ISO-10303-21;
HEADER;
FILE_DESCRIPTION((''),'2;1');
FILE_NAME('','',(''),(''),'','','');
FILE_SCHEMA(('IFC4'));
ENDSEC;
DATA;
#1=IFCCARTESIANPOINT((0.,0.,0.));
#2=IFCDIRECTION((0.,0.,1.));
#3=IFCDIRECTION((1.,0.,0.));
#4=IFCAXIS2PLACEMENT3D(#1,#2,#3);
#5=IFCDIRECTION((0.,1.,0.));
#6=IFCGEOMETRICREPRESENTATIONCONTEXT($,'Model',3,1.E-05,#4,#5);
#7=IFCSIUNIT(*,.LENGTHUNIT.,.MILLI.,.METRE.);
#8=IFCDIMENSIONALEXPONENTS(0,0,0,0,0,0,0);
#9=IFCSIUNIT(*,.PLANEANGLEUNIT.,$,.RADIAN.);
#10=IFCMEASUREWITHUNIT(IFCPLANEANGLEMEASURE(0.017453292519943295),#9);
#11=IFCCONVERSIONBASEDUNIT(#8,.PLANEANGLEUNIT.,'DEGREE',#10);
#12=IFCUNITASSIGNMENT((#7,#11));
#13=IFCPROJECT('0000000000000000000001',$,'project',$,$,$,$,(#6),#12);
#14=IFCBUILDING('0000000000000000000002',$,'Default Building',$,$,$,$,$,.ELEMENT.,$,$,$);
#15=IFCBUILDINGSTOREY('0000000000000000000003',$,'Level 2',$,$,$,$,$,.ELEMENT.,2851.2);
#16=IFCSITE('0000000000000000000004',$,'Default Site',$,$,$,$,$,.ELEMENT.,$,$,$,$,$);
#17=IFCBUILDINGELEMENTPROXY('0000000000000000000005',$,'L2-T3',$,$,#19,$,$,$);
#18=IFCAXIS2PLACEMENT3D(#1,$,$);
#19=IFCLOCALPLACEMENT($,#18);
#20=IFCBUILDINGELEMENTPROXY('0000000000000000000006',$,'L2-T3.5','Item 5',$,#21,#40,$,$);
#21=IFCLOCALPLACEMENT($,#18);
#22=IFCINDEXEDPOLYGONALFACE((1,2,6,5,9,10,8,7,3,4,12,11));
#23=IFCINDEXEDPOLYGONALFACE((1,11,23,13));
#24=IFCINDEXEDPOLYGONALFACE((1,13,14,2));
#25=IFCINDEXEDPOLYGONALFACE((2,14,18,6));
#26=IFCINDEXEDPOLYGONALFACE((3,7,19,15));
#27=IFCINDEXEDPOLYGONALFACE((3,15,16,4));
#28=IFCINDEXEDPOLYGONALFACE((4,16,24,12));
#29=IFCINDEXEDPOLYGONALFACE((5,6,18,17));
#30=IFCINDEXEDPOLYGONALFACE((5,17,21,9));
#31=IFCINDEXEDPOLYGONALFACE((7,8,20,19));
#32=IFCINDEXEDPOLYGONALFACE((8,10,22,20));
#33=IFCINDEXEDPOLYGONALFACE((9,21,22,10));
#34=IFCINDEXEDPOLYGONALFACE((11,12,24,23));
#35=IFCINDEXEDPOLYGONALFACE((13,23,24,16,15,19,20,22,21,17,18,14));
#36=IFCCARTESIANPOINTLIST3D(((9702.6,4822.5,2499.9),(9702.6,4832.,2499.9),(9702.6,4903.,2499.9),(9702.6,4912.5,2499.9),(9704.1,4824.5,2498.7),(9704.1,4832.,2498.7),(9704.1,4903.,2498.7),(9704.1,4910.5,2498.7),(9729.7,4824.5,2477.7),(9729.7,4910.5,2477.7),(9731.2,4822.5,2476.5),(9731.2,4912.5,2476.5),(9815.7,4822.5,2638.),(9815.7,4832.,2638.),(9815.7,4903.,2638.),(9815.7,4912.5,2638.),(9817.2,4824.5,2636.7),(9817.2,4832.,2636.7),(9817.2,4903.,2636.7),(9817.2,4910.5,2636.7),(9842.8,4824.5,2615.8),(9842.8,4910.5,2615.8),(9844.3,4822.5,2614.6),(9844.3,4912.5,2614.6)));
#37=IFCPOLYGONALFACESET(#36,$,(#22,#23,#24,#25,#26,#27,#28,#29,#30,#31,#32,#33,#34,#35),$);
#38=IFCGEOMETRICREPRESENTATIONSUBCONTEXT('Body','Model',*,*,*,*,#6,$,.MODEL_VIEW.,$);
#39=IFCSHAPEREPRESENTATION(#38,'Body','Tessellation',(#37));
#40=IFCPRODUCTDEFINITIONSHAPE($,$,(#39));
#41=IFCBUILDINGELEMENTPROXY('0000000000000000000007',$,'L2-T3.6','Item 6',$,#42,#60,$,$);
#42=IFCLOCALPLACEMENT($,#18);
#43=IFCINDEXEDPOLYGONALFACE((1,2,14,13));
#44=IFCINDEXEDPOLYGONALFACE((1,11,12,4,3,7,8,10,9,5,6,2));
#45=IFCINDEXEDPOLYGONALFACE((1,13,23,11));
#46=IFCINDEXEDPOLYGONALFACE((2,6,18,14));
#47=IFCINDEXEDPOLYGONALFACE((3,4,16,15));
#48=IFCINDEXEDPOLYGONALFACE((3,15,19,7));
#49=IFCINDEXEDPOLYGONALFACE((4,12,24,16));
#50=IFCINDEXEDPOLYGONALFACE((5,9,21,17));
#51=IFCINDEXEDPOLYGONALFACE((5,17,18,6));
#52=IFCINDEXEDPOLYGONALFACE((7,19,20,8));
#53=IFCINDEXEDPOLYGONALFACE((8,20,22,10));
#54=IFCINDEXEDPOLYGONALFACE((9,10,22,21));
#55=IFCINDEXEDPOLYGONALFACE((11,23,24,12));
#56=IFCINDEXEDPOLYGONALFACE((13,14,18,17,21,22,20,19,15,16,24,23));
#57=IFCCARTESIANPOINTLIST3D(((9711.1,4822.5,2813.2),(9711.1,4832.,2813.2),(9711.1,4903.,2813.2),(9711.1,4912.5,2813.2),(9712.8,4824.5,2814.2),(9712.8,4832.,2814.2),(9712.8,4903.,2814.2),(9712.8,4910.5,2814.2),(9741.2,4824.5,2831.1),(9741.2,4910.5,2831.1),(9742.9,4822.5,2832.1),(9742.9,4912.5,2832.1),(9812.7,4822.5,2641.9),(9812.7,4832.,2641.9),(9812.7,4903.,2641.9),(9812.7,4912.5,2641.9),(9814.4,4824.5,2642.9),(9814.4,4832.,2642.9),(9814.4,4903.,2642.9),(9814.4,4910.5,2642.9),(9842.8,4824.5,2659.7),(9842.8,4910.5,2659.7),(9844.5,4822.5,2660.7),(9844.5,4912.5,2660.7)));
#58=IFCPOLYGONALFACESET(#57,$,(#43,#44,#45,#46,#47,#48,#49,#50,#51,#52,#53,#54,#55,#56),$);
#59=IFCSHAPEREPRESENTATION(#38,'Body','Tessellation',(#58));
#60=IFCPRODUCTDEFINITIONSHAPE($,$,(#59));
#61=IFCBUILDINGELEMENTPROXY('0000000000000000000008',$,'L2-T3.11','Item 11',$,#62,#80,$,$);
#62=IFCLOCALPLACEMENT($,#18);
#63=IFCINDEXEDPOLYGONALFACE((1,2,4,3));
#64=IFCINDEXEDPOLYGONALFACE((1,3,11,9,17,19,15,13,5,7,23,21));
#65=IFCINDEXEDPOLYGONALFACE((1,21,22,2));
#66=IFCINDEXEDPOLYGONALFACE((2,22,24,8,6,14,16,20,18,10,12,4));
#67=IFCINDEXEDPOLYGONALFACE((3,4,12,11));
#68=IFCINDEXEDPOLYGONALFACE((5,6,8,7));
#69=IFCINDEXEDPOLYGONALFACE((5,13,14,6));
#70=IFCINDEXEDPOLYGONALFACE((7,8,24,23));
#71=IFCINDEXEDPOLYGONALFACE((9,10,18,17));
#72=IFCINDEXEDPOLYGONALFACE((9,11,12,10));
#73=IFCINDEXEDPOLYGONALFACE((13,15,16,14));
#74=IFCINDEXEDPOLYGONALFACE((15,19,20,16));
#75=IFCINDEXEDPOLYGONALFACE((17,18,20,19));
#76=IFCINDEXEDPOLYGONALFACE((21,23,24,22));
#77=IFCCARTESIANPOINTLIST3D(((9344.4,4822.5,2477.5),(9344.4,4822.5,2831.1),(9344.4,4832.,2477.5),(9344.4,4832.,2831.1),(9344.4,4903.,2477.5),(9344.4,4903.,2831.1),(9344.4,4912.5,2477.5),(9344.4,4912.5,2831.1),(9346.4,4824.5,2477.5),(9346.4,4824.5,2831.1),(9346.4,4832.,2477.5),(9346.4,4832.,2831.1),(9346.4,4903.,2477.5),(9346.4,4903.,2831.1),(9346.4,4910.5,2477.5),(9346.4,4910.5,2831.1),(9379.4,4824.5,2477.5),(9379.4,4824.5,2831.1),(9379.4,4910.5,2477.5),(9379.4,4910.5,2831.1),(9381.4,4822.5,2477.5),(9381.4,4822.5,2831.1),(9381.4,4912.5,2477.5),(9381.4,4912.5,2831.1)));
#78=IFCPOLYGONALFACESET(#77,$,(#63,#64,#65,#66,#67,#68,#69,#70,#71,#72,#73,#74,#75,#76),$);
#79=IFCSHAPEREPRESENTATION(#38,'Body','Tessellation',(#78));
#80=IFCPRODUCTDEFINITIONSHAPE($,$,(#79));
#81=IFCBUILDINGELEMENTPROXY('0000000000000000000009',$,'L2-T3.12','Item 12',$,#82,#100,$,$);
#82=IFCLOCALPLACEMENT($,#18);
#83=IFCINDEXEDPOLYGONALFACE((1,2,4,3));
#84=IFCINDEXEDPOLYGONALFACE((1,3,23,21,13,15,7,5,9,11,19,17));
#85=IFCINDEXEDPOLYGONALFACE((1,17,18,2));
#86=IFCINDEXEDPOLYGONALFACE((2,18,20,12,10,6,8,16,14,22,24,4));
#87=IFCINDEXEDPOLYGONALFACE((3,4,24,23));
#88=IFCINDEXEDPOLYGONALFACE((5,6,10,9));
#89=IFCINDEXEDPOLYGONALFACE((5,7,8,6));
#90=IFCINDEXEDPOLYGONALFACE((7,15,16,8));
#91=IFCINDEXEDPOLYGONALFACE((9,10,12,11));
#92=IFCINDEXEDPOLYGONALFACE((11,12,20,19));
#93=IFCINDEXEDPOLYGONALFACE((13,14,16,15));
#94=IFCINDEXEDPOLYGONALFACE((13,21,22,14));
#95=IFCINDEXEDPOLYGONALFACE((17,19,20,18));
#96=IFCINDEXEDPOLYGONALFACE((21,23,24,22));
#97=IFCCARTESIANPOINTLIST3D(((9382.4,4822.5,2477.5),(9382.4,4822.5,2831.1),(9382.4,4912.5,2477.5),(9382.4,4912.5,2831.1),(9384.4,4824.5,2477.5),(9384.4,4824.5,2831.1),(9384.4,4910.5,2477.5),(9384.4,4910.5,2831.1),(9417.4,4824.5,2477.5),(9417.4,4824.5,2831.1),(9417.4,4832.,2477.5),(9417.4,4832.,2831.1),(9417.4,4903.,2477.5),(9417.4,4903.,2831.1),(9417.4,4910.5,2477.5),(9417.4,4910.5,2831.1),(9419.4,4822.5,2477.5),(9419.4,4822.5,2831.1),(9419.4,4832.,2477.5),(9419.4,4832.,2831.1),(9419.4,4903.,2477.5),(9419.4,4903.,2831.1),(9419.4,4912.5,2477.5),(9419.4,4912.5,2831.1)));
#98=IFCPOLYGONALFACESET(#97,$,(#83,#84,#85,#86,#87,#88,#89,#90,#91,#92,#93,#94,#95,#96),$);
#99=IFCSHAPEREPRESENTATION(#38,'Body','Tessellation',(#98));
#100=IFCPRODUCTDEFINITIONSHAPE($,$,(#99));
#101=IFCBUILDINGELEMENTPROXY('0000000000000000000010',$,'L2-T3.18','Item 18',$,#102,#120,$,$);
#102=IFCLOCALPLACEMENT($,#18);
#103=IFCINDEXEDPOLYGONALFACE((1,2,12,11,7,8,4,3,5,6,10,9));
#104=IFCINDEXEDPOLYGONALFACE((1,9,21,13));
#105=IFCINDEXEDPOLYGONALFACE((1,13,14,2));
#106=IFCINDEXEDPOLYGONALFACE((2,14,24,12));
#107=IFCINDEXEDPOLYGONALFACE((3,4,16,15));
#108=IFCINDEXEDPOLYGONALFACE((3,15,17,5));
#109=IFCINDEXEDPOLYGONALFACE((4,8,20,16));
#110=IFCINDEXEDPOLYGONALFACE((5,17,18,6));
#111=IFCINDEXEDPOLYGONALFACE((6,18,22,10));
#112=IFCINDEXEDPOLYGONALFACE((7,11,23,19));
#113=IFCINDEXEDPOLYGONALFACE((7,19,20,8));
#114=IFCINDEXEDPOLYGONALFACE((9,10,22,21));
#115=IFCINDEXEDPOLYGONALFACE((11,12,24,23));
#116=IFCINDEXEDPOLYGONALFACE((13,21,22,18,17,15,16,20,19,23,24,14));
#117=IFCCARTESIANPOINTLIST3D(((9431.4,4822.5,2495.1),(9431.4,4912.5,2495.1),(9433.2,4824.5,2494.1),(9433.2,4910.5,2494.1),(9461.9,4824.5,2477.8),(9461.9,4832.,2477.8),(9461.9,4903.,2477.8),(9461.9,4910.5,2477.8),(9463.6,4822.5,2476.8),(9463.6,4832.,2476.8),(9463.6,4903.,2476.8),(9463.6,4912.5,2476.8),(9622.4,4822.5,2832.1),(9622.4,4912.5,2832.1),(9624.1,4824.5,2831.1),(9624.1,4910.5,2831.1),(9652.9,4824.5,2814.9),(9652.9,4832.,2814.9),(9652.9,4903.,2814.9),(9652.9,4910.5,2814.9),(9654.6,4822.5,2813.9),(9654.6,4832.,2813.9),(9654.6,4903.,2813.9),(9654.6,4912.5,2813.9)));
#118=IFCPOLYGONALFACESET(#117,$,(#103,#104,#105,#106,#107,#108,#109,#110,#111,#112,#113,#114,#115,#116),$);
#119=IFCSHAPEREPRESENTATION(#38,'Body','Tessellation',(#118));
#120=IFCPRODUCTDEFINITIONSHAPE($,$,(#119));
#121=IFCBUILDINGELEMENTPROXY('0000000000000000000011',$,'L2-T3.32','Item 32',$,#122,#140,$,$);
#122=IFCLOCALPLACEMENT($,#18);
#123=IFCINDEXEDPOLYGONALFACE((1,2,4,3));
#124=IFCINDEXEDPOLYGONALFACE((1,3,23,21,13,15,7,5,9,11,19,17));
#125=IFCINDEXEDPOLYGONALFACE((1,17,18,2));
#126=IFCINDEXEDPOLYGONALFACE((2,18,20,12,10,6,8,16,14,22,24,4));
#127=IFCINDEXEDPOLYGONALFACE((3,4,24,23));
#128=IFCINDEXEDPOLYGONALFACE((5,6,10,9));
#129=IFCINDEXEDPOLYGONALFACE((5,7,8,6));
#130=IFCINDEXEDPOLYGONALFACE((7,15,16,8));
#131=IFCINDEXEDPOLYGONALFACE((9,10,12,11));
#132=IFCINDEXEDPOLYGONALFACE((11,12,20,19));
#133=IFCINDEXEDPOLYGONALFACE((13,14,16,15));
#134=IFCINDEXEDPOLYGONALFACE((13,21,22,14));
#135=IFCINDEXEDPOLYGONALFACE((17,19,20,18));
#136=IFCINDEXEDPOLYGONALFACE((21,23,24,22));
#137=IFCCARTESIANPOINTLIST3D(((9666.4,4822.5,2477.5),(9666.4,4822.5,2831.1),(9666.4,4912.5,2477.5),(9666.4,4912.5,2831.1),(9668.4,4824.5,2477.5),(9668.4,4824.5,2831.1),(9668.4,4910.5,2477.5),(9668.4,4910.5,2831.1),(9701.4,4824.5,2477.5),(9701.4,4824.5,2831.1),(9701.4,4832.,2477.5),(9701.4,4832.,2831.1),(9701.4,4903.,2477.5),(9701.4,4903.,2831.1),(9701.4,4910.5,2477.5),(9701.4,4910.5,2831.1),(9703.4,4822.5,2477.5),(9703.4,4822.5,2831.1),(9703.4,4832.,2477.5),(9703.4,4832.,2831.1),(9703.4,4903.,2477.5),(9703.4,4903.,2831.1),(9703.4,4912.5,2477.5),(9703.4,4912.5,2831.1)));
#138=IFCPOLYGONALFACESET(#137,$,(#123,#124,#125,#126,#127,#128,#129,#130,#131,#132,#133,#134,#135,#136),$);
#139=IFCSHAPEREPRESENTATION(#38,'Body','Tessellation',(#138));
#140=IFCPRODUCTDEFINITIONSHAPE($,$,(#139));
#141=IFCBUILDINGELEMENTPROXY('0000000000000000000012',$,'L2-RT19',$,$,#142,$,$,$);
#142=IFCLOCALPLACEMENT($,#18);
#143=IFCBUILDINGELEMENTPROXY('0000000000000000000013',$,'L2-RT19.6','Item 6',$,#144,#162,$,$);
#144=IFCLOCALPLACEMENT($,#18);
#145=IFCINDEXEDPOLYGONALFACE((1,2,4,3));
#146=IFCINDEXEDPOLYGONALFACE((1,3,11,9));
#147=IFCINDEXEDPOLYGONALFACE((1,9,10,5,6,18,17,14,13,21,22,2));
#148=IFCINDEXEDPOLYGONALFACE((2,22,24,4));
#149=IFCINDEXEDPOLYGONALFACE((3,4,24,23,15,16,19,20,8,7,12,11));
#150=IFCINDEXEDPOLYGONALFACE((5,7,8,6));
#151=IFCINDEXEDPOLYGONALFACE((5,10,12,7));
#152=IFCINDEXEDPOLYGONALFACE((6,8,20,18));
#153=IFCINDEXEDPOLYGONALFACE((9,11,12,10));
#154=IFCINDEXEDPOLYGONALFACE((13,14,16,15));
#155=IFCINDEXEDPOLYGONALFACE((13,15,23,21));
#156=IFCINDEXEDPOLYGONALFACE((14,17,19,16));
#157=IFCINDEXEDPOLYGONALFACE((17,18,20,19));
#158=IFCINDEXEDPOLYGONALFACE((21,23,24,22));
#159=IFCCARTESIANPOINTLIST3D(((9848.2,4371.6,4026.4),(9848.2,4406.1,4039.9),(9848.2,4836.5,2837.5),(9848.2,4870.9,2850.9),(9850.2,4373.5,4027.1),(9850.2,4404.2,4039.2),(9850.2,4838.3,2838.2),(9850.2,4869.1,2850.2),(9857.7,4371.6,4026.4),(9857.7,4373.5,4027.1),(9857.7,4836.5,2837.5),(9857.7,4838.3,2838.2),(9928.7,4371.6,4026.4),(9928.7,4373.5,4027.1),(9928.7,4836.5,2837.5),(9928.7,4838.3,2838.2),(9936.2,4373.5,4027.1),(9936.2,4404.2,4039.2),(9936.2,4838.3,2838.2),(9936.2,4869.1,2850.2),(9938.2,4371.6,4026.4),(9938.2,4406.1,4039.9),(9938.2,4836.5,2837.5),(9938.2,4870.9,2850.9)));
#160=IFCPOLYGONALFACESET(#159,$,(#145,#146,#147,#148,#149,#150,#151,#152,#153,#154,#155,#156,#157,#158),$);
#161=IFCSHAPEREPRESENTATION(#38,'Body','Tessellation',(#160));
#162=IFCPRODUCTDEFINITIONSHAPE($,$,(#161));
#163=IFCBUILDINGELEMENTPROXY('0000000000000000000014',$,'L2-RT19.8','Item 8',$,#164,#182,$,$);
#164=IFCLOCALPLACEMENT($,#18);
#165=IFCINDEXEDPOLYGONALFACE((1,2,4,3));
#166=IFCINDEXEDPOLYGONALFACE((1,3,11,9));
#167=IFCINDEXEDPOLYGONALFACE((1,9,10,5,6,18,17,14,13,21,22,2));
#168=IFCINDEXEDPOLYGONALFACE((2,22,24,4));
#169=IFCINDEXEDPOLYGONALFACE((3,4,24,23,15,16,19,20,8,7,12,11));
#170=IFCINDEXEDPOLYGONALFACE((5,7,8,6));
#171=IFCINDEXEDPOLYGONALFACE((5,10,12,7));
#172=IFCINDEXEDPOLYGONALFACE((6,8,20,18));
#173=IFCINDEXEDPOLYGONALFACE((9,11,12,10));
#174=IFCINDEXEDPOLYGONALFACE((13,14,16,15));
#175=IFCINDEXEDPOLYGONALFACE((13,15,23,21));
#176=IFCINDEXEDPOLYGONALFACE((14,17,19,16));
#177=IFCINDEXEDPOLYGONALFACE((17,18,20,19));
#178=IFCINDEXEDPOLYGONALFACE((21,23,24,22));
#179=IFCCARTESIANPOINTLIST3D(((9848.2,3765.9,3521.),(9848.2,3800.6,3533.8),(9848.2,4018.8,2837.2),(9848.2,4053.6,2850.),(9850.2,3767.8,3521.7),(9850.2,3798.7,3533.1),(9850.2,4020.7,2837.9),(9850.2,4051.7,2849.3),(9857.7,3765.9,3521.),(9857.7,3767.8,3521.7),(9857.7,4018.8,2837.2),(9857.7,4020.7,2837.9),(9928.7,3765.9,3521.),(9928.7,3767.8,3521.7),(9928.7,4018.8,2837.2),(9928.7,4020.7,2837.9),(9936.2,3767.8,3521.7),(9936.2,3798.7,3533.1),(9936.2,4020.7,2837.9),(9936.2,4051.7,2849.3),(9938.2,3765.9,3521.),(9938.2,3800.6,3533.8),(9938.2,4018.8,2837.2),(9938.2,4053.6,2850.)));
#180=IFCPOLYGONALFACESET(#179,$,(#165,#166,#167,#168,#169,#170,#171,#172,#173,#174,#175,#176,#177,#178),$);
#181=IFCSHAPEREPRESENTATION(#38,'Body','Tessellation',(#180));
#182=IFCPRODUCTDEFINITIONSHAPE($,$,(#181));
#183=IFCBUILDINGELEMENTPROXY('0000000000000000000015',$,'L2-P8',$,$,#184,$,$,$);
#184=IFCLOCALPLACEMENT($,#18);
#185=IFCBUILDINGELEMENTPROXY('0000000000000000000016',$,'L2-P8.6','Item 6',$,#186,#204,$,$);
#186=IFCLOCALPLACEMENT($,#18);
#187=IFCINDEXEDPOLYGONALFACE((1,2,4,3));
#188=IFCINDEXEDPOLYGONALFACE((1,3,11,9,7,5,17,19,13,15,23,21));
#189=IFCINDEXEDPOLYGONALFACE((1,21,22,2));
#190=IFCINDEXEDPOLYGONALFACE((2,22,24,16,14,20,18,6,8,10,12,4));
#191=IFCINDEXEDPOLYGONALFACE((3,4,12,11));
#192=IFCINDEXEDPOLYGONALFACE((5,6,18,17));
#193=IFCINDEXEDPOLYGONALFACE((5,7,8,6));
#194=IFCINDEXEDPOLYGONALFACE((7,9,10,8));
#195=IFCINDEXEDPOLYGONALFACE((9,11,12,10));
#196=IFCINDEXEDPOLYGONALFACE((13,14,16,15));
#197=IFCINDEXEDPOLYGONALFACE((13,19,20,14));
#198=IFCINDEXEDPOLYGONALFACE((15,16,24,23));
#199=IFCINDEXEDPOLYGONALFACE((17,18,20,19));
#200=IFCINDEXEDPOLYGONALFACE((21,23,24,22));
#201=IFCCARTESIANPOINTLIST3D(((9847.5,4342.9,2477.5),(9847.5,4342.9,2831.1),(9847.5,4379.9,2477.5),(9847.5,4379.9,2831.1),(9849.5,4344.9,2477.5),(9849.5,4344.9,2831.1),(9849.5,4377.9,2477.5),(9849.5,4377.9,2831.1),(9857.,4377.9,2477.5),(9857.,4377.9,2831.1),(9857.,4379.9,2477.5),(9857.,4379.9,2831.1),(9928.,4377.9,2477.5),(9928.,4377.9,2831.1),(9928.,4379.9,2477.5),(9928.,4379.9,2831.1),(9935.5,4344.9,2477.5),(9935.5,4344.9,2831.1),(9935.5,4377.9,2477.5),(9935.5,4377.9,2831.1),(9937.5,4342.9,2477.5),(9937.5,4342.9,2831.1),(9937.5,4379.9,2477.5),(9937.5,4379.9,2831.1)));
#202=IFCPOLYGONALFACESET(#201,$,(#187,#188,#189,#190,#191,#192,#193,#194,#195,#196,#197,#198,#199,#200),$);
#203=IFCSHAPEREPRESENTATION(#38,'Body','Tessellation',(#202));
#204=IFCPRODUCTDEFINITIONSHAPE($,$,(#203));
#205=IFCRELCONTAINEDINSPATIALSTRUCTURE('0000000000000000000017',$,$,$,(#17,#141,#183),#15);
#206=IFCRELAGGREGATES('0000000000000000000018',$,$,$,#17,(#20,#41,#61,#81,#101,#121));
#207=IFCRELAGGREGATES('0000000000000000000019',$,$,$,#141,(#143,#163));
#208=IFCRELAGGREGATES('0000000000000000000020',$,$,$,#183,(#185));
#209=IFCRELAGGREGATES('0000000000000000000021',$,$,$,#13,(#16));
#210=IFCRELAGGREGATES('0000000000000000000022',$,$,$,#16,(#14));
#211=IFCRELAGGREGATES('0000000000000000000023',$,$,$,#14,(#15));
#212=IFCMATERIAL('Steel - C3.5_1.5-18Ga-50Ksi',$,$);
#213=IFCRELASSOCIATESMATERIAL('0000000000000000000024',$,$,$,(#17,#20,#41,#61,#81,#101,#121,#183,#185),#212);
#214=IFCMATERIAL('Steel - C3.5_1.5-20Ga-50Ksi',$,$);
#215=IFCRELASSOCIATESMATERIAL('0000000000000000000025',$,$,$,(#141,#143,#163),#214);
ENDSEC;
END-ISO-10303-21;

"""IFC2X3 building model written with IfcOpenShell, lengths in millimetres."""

from ifc_helpers import new_model, entity, si_unit, converted_unit, direction, frame, origin, origin_with_axes, origin_2d_with_axis, place, context, subcontext, project, spatial, c_section, extrude, material, element, aggregate, save


model = new_model("IFC2X3")

# Units and contexts
model_context = context("Model", 3, precision=1e-05, world=origin_with_axes(), true_north=direction((0.0, 1.0, 0.0)))
body_context = subcontext(model_context, "Body", "Model", "MODEL_VIEW")
ifc_project = project(units=[si_unit("LENGTHUNIT", "METRE", prefix="MILLI"), converted_unit("PLANEANGLEUNIT", "DEGREE", entity("IfcPlaneAngleMeasure", 0.017453292519943295), si_unit("PLANEANGLEUNIT", "RADIAN"), dimensions=[0, 0, 0, 0, 0, 0, 0])], contexts=[model_context])

# Site, building, storey
site = spatial("IfcSite", under=ifc_project, Name="Default Site", CompositionType="ELEMENT")
building = spatial("IfcBuilding", under=site, Name="Default Building", CompositionType="ELEMENT")
storey = spatial("IfcBuildingStorey", under=building, Name="Level 2", CompositionType="ELEMENT", Elevation=2851.2)

# Building element proxies
ifc_material_1 = material(Name="Steel - C3.5_1.5-18Ga-50Ksi")
proxy_1 = element("IfcBuildingElementProxy", 1, inside=storey, material=ifc_material_1, Name="L2-T3")
proxy_2_placement = place(None, frame((9716.9, 4867.5, 2488.2), z_axis=(0.634, 0.0, 0.774), x_axis=(-28.628, 0.0, 23.44)))
proxy_2 = element("IfcBuildingElementProxy", 2, at=proxy_2_placement, material=ifc_material_1, Name="L2-T3.5", Description="Item 5", context=body_context, shape_type="SweptSolid", body=[
    extrude(c_section(Depth=90.0, Width=37.0, WallThickness=2.0, Girth=9.5, at=origin_2d_with_axis()), origin(), (0.0, 0.0, 1.0), 178.5),
])
proxy_3_placement = place(None, frame((9828.6, 4867.5, 2651.3), z_axis=(-0.51, 0.0, 0.86), x_axis=(-31.825, 0.0, -18.873)))
proxy_3 = element("IfcBuildingElementProxy", 3, at=proxy_3_placement, material=ifc_material_1, Name="L2-T3.6", Description="Item 6", context=body_context, shape_type="SweptSolid", body=[
    extrude(c_section(Depth=90.0, Width=37.0, WallThickness=2.0, Girth=9.5, at=origin_2d_with_axis()), origin(), (0.0, 0.0, 1.0), 199.2),
])
proxy_4_placement = place(None, frame((9362.9, 4867.5, 2477.5), z_axis=(0.0, 0.0, 1.0), x_axis=(-37.0, 0.0, 0.0)))
proxy_4 = element("IfcBuildingElementProxy", 4, at=proxy_4_placement, material=ifc_material_1, Name="L2-T3.11", Description="Item 11", context=body_context, shape_type="SweptSolid", body=[
    extrude(c_section(Depth=90.0, Width=37.0, WallThickness=2.0, Girth=9.5, at=origin_2d_with_axis()), origin(), (0.0, 0.0, 1.0), 353.6),
])
proxy_5_placement = place(None, frame((9400.9, 4867.5, 2831.1), z_axis=(0.0, 0.0, -1.0), x_axis=(37.0, 0.0, 0.0)))
proxy_5 = element("IfcBuildingElementProxy", 5, at=proxy_5_placement, material=ifc_material_1, Name="L2-T3.12", Description="Item 12", context=body_context, shape_type="SweptSolid", body=[
    extrude(c_section(Depth=90.0, Width=37.0, WallThickness=2.0, Girth=9.5, at=origin_2d_with_axis()), origin(), (0.0, 0.0, 1.0), 353.6),
])
proxy_6_placement = place(None, frame((9638.5, 4867.5, 2823.0), z_axis=(-0.493, 0.0, -0.87), x_axis=(32.192, 0.0, -18.239)))
proxy_6 = element("IfcBuildingElementProxy", 6, at=proxy_6_placement, material=ifc_material_1, Name="L2-T3.18", Description="Item 18", context=body_context, shape_type="SweptSolid", body=[
    extrude(c_section(Depth=90.0, Width=37.0, WallThickness=2.0, Girth=9.5, at=origin_2d_with_axis()), origin(), (0.0, 0.0, 1.0), 387.4),
])
proxy_7_placement = place(None, frame((9684.9, 4867.5, 2831.1), z_axis=(0.0, 0.0, -1.0), x_axis=(37.0, 0.0, 0.0)))
proxy_7 = element("IfcBuildingElementProxy", 7, at=proxy_7_placement, material=ifc_material_1, Name="L2-T3.32", Description="Item 32", context=body_context, shape_type="SweptSolid", body=[
    extrude(c_section(Depth=90.0, Width=37.0, WallThickness=2.0, Girth=9.5, at=origin_2d_with_axis()), origin(), (0.0, 0.0, 1.0), 353.6),
])
aggregate(proxy_1, [proxy_2, proxy_3, proxy_4, proxy_5, proxy_6, proxy_7])
ifc_material_2 = material(Name="Steel - C3.5_1.5-20Ga-50Ksi")
proxy_8 = element("IfcBuildingElementProxy", 8, inside=storey, material=ifc_material_2, Name="L2-RT19")
proxy_9_placement = place(None, frame((9893.2, 4853.7, 2844.2), z_axis=(0.0, -0.364, 0.931), x_axis=(0.0, -34.462, -13.467)))
proxy_9 = element("IfcBuildingElementProxy", 9, at=proxy_9_placement, material=ifc_material_2, Name="L2-RT19.6", Description="Item 6", context=body_context, shape_type="SweptSolid", body=[
    extrude(c_section(Depth=90.0, Width=37.0, WallThickness=2.0, Girth=9.5, at=origin_2d_with_axis()), origin(), (0.0, 0.0, 1.0), 1276.6),
])
proxy_10_placement = place(None, frame((9893.2, 4036.2, 2843.6), z_axis=(0.0, -0.347, 0.938), x_axis=(0.0, -34.701, -12.84)))
proxy_10 = element("IfcBuildingElementProxy", 10, at=proxy_10_placement, material=ifc_material_2, Name="L2-RT19.8", Description="Item 8", context=body_context, shape_type="SweptSolid", body=[
    extrude(c_section(Depth=90.0, Width=37.0, WallThickness=2.0, Girth=9.5, at=origin_2d_with_axis()), origin(), (0.0, 0.0, 1.0), 729.1),
])
aggregate(proxy_8, [proxy_9, proxy_10])
proxy_11 = element("IfcBuildingElementProxy", 11, inside=storey, material=ifc_material_1, Name="L2-P8")
proxy_12_placement = place(None, frame((9892.5, 4361.4, 2477.5), z_axis=(0.0, 0.0, 1.0), x_axis=(0.0, 37.0, 0.0)))
proxy_12 = element("IfcBuildingElementProxy", 12, at=proxy_12_placement, material=ifc_material_1, Name="L2-P8.6", Description="Item 6", context=body_context, shape_type="SweptSolid", body=[
    extrude(c_section(Depth=90.0, Width=37.0, WallThickness=2.0, Girth=9.5, at=origin_2d_with_axis()), origin(), (0.0, 0.0, 1.0), 353.6),
])
aggregate(proxy_11, [proxy_12])

save(model, "model.ifc")
